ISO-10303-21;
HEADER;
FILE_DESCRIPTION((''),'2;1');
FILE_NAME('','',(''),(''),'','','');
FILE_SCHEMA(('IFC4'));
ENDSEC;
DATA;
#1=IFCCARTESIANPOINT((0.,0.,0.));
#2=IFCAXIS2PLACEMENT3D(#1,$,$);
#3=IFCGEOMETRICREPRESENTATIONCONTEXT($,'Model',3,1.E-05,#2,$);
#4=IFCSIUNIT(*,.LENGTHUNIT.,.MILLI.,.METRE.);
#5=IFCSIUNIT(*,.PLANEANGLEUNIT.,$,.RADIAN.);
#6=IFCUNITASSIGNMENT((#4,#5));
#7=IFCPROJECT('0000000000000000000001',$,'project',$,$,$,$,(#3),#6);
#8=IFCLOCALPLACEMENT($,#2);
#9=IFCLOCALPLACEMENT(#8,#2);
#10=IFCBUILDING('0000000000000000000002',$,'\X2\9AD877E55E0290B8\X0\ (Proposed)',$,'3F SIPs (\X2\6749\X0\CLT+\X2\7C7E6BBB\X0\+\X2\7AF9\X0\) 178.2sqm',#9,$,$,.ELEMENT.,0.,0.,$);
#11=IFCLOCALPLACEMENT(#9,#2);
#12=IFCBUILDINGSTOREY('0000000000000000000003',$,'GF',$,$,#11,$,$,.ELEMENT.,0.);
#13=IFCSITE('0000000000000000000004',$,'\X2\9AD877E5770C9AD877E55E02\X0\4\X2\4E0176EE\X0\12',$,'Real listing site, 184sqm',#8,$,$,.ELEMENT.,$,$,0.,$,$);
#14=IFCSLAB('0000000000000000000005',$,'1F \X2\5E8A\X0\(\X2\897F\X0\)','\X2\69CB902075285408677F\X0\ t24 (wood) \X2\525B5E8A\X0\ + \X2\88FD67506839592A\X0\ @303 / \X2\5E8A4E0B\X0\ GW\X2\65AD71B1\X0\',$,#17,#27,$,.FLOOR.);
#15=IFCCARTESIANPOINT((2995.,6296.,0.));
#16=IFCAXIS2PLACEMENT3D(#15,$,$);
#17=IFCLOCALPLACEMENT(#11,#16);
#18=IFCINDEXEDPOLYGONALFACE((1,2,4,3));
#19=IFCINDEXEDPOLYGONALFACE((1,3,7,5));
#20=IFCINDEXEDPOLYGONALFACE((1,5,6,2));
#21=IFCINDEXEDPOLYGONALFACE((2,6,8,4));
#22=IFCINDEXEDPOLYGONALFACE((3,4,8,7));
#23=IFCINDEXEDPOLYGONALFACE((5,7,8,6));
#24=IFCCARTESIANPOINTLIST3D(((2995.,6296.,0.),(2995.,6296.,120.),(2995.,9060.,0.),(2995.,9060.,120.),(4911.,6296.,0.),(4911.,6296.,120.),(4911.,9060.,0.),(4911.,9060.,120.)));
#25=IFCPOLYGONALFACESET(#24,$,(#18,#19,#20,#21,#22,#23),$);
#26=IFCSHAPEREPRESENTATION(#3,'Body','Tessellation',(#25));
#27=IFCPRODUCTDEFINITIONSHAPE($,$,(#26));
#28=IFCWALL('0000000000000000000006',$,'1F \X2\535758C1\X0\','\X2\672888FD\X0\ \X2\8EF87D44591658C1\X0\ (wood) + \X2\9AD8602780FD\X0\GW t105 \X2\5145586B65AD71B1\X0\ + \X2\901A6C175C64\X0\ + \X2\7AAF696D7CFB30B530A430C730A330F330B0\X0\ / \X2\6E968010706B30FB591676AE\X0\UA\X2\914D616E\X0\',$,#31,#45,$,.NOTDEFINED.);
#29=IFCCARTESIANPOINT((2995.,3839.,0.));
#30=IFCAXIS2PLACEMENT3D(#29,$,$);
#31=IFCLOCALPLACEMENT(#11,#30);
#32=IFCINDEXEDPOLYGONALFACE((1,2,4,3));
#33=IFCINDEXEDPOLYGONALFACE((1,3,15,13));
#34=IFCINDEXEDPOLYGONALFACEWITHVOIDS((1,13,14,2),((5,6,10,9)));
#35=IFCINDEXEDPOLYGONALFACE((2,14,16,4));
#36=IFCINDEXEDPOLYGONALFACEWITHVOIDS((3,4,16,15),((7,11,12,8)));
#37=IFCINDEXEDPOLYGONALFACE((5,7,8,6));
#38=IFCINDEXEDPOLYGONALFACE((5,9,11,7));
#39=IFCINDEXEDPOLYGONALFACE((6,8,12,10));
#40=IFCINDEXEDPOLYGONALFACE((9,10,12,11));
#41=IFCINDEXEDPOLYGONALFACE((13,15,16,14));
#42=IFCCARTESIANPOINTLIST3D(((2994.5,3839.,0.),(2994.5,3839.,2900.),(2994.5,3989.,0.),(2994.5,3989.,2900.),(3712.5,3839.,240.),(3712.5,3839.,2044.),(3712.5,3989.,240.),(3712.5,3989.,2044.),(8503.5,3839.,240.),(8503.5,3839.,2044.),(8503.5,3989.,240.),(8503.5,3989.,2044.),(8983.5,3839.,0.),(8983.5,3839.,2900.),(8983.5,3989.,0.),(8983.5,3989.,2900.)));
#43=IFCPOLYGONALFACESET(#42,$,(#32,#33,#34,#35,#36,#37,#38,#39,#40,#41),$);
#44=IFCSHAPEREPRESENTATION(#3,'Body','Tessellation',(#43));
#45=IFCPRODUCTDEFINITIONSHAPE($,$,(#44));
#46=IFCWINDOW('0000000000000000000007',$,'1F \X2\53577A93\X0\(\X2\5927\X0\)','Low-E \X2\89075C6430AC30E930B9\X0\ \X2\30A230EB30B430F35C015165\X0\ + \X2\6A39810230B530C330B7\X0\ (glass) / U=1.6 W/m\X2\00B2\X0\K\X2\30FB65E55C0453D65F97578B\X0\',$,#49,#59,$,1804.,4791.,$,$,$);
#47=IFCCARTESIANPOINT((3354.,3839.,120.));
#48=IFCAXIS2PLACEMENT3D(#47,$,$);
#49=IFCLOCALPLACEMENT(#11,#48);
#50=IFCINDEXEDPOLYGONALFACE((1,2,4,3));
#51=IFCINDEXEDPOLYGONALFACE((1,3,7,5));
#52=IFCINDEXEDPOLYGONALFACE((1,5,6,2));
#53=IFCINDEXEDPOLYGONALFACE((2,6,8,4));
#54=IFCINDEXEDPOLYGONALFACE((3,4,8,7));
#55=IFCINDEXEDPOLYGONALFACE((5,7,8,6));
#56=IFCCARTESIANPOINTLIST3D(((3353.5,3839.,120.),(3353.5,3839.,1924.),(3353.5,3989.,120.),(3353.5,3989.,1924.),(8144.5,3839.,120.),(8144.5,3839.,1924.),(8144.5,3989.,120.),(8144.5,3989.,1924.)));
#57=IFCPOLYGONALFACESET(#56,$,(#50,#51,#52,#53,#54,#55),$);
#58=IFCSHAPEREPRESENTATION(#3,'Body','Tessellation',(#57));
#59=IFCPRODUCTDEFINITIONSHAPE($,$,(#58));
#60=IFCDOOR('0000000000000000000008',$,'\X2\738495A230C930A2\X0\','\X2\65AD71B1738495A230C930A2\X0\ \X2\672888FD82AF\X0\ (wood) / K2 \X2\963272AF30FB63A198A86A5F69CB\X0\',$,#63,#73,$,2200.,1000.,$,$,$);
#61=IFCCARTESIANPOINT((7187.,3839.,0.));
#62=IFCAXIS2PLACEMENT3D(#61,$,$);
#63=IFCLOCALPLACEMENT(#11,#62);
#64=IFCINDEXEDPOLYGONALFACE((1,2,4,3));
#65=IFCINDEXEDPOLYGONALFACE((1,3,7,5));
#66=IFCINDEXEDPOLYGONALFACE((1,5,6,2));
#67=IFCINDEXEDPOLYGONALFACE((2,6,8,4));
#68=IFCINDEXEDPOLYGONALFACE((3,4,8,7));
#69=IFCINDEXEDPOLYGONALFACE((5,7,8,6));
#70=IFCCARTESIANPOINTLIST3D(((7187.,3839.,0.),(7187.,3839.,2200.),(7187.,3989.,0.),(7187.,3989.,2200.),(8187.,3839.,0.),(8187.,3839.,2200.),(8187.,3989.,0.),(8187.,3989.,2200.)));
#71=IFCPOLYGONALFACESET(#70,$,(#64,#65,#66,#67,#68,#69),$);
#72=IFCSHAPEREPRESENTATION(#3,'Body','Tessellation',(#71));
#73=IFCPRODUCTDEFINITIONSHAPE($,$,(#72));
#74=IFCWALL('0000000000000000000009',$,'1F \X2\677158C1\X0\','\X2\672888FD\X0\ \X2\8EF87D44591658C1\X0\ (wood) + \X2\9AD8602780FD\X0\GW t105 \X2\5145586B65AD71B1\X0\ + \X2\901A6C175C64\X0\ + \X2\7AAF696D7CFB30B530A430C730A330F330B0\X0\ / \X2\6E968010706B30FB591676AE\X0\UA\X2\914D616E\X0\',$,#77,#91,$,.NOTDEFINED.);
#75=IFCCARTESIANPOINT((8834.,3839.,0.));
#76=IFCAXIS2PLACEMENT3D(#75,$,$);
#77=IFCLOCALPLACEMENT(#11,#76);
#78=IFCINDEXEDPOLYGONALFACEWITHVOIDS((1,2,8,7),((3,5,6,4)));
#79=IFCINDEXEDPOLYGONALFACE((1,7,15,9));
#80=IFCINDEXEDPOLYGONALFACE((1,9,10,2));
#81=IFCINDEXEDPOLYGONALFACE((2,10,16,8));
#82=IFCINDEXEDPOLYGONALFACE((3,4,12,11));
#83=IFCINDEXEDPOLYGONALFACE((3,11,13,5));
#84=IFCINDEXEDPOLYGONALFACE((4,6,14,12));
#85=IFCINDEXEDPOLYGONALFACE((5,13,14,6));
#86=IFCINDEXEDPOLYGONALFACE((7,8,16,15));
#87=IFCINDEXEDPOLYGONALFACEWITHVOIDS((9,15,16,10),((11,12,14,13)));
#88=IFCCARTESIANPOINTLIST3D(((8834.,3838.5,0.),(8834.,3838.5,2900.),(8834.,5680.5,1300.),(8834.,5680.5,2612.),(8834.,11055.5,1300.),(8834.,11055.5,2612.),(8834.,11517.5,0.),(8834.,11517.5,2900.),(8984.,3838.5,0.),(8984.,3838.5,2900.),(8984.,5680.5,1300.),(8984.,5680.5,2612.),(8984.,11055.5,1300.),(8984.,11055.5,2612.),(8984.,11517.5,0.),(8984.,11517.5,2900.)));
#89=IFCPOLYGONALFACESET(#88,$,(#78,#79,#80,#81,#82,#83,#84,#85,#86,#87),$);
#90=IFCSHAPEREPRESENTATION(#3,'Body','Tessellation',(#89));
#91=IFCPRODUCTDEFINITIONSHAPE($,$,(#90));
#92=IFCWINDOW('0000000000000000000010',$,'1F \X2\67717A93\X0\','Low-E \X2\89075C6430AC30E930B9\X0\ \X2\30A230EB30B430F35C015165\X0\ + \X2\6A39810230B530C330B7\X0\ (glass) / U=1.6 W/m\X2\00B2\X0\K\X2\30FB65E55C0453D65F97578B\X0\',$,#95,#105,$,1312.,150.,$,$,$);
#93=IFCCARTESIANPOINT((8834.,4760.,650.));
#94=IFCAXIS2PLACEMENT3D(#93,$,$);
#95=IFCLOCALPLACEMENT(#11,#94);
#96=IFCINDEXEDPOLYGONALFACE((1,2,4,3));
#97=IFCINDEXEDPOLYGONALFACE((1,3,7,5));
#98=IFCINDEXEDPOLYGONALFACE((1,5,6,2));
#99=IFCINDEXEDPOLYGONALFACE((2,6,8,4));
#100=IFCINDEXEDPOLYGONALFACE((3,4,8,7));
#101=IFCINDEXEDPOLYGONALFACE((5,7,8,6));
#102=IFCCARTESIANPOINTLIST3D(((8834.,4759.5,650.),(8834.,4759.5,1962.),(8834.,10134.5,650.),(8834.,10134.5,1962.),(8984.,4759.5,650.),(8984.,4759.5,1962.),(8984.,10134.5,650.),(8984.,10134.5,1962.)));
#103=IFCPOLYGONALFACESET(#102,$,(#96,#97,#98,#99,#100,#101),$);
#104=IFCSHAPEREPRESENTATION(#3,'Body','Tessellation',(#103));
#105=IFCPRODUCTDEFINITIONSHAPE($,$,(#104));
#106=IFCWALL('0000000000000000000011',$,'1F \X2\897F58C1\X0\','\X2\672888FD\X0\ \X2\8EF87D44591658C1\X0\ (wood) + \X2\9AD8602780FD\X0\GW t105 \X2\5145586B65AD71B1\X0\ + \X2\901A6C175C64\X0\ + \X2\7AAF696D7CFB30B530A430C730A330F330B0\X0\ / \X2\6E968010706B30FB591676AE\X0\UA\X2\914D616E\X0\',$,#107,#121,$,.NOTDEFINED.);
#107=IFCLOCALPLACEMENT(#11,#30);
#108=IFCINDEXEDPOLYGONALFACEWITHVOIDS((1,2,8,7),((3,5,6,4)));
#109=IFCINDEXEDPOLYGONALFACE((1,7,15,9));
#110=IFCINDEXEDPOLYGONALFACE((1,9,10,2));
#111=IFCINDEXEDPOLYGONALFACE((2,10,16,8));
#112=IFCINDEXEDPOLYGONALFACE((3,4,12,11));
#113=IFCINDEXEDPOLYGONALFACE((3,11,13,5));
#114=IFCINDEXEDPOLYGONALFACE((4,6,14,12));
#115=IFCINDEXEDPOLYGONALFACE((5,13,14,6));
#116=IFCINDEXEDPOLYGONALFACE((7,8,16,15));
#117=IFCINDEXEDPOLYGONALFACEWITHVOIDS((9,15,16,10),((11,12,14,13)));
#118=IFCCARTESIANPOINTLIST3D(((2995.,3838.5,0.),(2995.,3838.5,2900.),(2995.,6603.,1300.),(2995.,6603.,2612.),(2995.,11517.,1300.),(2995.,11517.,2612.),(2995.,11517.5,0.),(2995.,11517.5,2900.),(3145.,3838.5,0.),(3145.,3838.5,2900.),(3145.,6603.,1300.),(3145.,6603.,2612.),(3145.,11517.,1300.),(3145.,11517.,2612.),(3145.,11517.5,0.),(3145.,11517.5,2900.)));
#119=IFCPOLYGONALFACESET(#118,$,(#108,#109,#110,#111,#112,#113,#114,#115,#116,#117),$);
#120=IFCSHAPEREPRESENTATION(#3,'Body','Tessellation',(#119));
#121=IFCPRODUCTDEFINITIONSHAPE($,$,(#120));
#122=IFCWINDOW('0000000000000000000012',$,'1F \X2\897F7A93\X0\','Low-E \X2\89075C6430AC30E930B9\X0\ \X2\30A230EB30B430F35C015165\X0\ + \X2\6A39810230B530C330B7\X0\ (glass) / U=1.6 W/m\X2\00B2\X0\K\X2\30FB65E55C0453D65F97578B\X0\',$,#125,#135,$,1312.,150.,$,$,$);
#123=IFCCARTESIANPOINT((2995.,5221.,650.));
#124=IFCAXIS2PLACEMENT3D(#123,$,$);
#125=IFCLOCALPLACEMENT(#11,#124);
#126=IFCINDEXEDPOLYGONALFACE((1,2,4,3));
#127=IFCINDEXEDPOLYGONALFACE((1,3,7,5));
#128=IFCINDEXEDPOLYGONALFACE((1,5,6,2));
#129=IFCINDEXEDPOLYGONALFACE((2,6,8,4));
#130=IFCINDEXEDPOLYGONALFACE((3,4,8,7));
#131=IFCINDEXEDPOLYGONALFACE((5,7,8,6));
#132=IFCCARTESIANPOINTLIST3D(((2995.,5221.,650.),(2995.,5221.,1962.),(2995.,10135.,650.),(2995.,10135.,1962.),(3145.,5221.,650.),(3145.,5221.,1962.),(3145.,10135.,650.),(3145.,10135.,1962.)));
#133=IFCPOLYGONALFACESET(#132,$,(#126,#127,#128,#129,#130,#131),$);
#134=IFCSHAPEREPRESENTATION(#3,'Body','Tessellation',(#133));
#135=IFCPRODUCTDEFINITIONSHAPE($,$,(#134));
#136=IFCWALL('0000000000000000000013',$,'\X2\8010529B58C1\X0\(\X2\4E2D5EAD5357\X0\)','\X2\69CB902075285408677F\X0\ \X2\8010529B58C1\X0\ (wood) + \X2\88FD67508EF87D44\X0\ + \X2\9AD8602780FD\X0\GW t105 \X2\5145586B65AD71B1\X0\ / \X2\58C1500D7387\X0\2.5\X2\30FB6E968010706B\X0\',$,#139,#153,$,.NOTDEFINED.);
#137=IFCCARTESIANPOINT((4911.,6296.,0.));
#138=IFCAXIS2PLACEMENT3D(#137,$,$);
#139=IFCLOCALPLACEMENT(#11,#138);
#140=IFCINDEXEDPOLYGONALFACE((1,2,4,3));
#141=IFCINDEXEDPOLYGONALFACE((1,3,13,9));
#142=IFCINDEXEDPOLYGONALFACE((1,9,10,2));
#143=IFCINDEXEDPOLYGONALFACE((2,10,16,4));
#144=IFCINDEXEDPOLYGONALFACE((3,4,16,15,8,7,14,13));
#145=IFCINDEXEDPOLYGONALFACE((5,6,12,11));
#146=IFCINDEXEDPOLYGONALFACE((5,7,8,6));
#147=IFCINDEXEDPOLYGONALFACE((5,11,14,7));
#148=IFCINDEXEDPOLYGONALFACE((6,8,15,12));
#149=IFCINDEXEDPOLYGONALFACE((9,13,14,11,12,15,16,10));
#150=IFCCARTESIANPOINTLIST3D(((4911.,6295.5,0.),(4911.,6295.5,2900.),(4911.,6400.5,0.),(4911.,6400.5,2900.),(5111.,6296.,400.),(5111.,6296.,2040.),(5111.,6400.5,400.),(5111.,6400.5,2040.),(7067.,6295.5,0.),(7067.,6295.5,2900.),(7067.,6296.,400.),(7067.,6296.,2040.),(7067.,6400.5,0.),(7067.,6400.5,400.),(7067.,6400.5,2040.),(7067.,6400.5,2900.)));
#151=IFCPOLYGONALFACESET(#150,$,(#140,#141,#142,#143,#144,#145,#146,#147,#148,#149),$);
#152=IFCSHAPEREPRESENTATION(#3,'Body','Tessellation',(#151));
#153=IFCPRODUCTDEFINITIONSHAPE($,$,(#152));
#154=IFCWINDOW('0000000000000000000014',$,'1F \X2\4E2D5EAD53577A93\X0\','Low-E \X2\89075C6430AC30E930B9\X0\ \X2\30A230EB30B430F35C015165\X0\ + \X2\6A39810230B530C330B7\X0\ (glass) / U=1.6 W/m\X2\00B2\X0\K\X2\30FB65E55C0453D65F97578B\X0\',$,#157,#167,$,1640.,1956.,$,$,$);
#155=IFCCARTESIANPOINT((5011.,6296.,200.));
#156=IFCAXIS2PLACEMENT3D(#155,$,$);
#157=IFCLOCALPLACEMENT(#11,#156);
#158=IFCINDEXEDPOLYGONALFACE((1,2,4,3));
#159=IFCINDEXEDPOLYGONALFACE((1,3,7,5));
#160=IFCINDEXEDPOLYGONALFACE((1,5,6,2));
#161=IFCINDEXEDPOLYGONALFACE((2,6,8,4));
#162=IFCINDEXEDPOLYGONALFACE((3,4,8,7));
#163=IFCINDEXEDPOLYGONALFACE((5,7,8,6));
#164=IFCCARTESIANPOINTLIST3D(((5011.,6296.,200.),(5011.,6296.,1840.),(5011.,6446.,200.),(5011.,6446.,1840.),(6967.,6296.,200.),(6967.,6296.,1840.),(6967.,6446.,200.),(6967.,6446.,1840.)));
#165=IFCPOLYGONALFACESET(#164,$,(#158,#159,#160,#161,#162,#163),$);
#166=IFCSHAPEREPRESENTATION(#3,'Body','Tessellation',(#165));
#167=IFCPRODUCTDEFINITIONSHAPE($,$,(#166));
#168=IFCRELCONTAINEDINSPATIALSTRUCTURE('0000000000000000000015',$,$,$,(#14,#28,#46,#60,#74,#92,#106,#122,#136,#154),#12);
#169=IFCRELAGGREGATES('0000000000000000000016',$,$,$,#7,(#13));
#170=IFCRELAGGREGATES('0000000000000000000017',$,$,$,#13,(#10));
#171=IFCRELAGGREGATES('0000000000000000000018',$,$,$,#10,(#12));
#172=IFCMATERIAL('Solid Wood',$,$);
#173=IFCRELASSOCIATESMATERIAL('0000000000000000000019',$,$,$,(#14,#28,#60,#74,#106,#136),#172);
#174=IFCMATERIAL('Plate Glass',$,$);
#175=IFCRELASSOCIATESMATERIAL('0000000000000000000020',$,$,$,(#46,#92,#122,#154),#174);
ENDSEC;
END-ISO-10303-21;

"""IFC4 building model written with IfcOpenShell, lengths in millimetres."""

from ifc_helpers import new_model, si_unit, frame, frame_2d, origin, place, context, project, spatial, rectangle, extrude, material, element, fill, save


model = new_model("IFC4")

# Units and contexts
model_context = context("Model", 3, precision=1e-05, world=origin())
ifc_project = project(units=[si_unit("LENGTHUNIT", "METRE", prefix="MILLI"), si_unit("PLANEANGLEUNIT", "RADIAN")], contexts=[model_context])

# Site, building, storey
site_placement = place(None, origin())
site = spatial("IfcSite", under=ifc_project, at=site_placement, Name="高知県高知市4丁目12", ObjectType="Real listing site, 184sqm", CompositionType="ELEMENT", RefElevation=0.0)
building_placement = place(site_placement, origin())
building = spatial("IfcBuilding", under=site, at=building_placement, Name="高知市邸 (Proposed)", ObjectType="3F SIPs (杉CLT+籾殻+竹) 178.2sqm", CompositionType="ELEMENT", ElevationOfRefHeight=0.0, ElevationOfTerrain=0.0)
storey_placement = place(building_placement, origin())
storey = spatial("IfcBuildingStorey", under=building, at=storey_placement, Name="GF", CompositionType="ELEMENT", Elevation=0.0)

# Slab
ifc_material_1 = material(Name="Solid Wood")
slab_1_placement = place(storey_placement, frame((2995.0, 6296.0, 0.0)))
element("IfcSlab", 1, at=slab_1_placement, inside=storey, material=ifc_material_1, Name="1F 床(西)", Description="構造用合板 t24 (wood) 剛床 + 製材根太 @303 / 床下 GW断熱", PredefinedType="FLOOR", context=model_context, shape_type="SweptSolid", body=[
    extrude(rectangle(XDim=1916.0, YDim=2764.0, at=frame_2d((958.0, 1382.0))), frame((2995.0, 6296.0, 0.0)), (0.0, 0.0, 1.0), 120.0),
])

# Wall, openings, window, door
wall_1_placement = place(storey_placement, frame((2995.0, 3839.0, 0.0)))
wall_1 = element("IfcWall", 2, at=wall_1_placement, inside=storey, material=ifc_material_1, Name="1F 南壁", Description="木製 軸組外壁 (wood) + 高性能GW t105 充填断熱 + 通気層 + 窯業系サイディング / 準耐火・外皮UA配慮", PredefinedType="NOTDEFINED", context=model_context, shape_type="SweptSolid", body=[
    extrude(rectangle(XDim=5989.0, YDim=150.0, at=frame_2d((2994.0, 75.0))), frame((2995.0, 3839.0, 0.0)), (0.0, 0.0, 1.0), 2900.0),
])
opening_1_placement = place(storey_placement, frame((3354.0, 3839.0, 120.0)))
opening_1 = element("IfcOpeningElement", 3, at=opening_1_placement, cuts=wall_1, PredefinedType="NOTDEFINED", context=model_context, shape_type="SweptSolid", body=[
    extrude(rectangle(XDim=4791.0, YDim=150.0, at=frame_2d((2395.0, 75.0))), frame((3354.0, 3839.0, 120.0)), (0.0, 0.0, 1.0), 1804.0),
])
opening_2_placement = place(storey_placement, frame((7187.0, 3839.0, 0.0)))
opening_2 = element("IfcOpeningElement", 4, at=opening_2_placement, cuts=wall_1, PredefinedType="NOTDEFINED", context=model_context, shape_type="SweptSolid", body=[
    extrude(rectangle(XDim=1000.0, YDim=150.0, at=frame_2d((500.0, 75.0))), frame((7187.0, 3839.0, 0.0)), (0.0, 0.0, 1.0), 2200.0),
])
ifc_material_2 = material(Name="Plate Glass")
window_1_placement = place(storey_placement, frame((3354.0, 3839.0, 120.0)))
window_1 = element("IfcWindow", 5, at=window_1_placement, inside=storey, material=ifc_material_2, Name="1F 南窓(大)", Description="Low-E 複層ガラス アルゴン封入 + 樹脂サッシ (glass) / U=1.6 W/m²K・日射取得型", OverallHeight=1804.0, OverallWidth=4791.0, context=model_context, shape_type="SweptSolid", body=[
    extrude(rectangle(XDim=4791.0, YDim=150.0, at=frame_2d((2395.0, 75.0))), frame((3354.0, 3839.0, 120.0)), (0.0, 0.0, 1.0), 1804.0),
])
fill(opening_1, window_1)
door_placement = place(storey_placement, frame((7187.0, 3839.0, 0.0)))
door = element("IfcDoor", 6, at=door_placement, inside=storey, material=ifc_material_1, Name="玄関ドア", Description="断熱玄関ドア 木製芯 (wood) / K2 防犯・採風機構", OverallHeight=2200.0, OverallWidth=1000.0, context=model_context, shape_type="SweptSolid", body=[
    extrude(rectangle(XDim=1000.0, YDim=150.0, at=frame_2d((500.0, 75.0))), frame((7187.0, 3839.0, 0.0)), (0.0, 0.0, 1.0), 2200.0),
])
fill(opening_2, door)

# Walls, openings, windows
wall_2_placement = place(storey_placement, frame((8834.0, 3839.0, 0.0)))
wall_2 = element("IfcWall", 7, at=wall_2_placement, inside=storey, material=ifc_material_1, Name="1F 東壁", Description="木製 軸組外壁 (wood) + 高性能GW t105 充填断熱 + 通気層 + 窯業系サイディング / 準耐火・外皮UA配慮", PredefinedType="NOTDEFINED", context=model_context, shape_type="SweptSolid", body=[
    extrude(rectangle(XDim=150.0, YDim=7679.0, at=frame_2d((75.0, 3839.0))), frame((8834.0, 3839.0, 0.0)), (0.0, 0.0, 1.0), 2900.0),
])
opening_3_placement = place(storey_placement, frame((8834.0, 4760.0, 650.0)))
opening_3 = element("IfcOpeningElement", 8, at=opening_3_placement, cuts=wall_2, PredefinedType="NOTDEFINED", context=model_context, shape_type="SweptSolid", body=[
    extrude(rectangle(XDim=150.0, YDim=5375.0, at=frame_2d((75.0, 2687.0))), frame((8834.0, 4760.0, 650.0)), (0.0, 0.0, 1.0), 1312.0),
])
window_2_placement = place(storey_placement, frame((8834.0, 4760.0, 650.0)))
window_2 = element("IfcWindow", 9, at=window_2_placement, inside=storey, material=ifc_material_2, Name="1F 東窓", Description="Low-E 複層ガラス アルゴン封入 + 樹脂サッシ (glass) / U=1.6 W/m²K・日射取得型", OverallHeight=1312.0, OverallWidth=150.0, context=model_context, shape_type="SweptSolid", body=[
    extrude(rectangle(XDim=150.0, YDim=5375.0, at=frame_2d((75.0, 2687.0))), frame((8834.0, 4760.0, 650.0)), (0.0, 0.0, 1.0), 1312.0),
])
fill(opening_3, window_2)
wall_3_placement = place(storey_placement, frame((2995.0, 3839.0, 0.0)))
wall_3 = element("IfcWall", 10, at=wall_3_placement, inside=storey, material=ifc_material_1, Name="1F 西壁", Description="木製 軸組外壁 (wood) + 高性能GW t105 充填断熱 + 通気層 + 窯業系サイディング / 準耐火・外皮UA配慮", PredefinedType="NOTDEFINED", context=model_context, shape_type="SweptSolid", body=[
    extrude(rectangle(XDim=150.0, YDim=7679.0, at=frame_2d((75.0, 3839.0))), frame((2995.0, 3839.0, 0.0)), (0.0, 0.0, 1.0), 2900.0),
])
opening_4_placement = place(storey_placement, frame((2995.0, 5221.0, 650.0)))
opening_4 = element("IfcOpeningElement", 11, at=opening_4_placement, cuts=wall_3, PredefinedType="NOTDEFINED", context=model_context, shape_type="SweptSolid", body=[
    extrude(rectangle(XDim=150.0, YDim=4914.0, at=frame_2d((75.0, 2457.0))), frame((2995.0, 5221.0, 650.0)), (0.0, 0.0, 1.0), 1312.0),
])
window_3_placement = place(storey_placement, frame((2995.0, 5221.0, 650.0)))
window_3 = element("IfcWindow", 12, at=window_3_placement, inside=storey, material=ifc_material_2, Name="1F 西窓", Description="Low-E 複層ガラス アルゴン封入 + 樹脂サッシ (glass) / U=1.6 W/m²K・日射取得型", OverallHeight=1312.0, OverallWidth=150.0, context=model_context, shape_type="SweptSolid", body=[
    extrude(rectangle(XDim=150.0, YDim=4914.0, at=frame_2d((75.0, 2457.0))), frame((2995.0, 5221.0, 650.0)), (0.0, 0.0, 1.0), 1312.0),
])
fill(opening_4, window_3)
wall_4_placement = place(storey_placement, frame((4911.0, 6296.0, 0.0)))
wall_4 = element("IfcWall", 13, at=wall_4_placement, inside=storey, material=ifc_material_1, Name="耐力壁(中庭南)", Description="構造用合板 耐力壁 (wood) + 製材軸組 + 高性能GW t105 充填断熱 / 壁倍率2.5・準耐火", PredefinedType="NOTDEFINED", context=model_context, shape_type="SweptSolid", body=[
    extrude(rectangle(XDim=2156.0, YDim=105.0, at=frame_2d((1078.0, 52.0))), frame((4911.0, 6296.0, 0.0)), (0.0, 0.0, 1.0), 2900.0),
])
opening_5_placement = place(storey_placement, frame((5011.0, 6296.0, 200.0)))
opening_5 = element("IfcOpeningElement", 14, at=opening_5_placement, cuts=wall_4, PredefinedType="NOTDEFINED", context=model_context, shape_type="SweptSolid", body=[
    extrude(rectangle(XDim=1956.0, YDim=150.0, at=frame_2d((978.0, 75.0))), frame((5011.0, 6296.0, 200.0)), (0.0, 0.0, 1.0), 1640.0),
])
window_4_placement = place(storey_placement, frame((5011.0, 6296.0, 200.0)))
window_4 = element("IfcWindow", 15, at=window_4_placement, inside=storey, material=ifc_material_2, Name="1F 中庭南窓", Description="Low-E 複層ガラス アルゴン封入 + 樹脂サッシ (glass) / U=1.6 W/m²K・日射取得型", OverallHeight=1640.0, OverallWidth=1956.0, context=model_context, shape_type="SweptSolid", body=[
    extrude(rectangle(XDim=1956.0, YDim=150.0, at=frame_2d((978.0, 75.0))), frame((5011.0, 6296.0, 200.0)), (0.0, 0.0, 1.0), 1640.0),
])
fill(opening_5, window_4)

save(model, "model.ifc")
